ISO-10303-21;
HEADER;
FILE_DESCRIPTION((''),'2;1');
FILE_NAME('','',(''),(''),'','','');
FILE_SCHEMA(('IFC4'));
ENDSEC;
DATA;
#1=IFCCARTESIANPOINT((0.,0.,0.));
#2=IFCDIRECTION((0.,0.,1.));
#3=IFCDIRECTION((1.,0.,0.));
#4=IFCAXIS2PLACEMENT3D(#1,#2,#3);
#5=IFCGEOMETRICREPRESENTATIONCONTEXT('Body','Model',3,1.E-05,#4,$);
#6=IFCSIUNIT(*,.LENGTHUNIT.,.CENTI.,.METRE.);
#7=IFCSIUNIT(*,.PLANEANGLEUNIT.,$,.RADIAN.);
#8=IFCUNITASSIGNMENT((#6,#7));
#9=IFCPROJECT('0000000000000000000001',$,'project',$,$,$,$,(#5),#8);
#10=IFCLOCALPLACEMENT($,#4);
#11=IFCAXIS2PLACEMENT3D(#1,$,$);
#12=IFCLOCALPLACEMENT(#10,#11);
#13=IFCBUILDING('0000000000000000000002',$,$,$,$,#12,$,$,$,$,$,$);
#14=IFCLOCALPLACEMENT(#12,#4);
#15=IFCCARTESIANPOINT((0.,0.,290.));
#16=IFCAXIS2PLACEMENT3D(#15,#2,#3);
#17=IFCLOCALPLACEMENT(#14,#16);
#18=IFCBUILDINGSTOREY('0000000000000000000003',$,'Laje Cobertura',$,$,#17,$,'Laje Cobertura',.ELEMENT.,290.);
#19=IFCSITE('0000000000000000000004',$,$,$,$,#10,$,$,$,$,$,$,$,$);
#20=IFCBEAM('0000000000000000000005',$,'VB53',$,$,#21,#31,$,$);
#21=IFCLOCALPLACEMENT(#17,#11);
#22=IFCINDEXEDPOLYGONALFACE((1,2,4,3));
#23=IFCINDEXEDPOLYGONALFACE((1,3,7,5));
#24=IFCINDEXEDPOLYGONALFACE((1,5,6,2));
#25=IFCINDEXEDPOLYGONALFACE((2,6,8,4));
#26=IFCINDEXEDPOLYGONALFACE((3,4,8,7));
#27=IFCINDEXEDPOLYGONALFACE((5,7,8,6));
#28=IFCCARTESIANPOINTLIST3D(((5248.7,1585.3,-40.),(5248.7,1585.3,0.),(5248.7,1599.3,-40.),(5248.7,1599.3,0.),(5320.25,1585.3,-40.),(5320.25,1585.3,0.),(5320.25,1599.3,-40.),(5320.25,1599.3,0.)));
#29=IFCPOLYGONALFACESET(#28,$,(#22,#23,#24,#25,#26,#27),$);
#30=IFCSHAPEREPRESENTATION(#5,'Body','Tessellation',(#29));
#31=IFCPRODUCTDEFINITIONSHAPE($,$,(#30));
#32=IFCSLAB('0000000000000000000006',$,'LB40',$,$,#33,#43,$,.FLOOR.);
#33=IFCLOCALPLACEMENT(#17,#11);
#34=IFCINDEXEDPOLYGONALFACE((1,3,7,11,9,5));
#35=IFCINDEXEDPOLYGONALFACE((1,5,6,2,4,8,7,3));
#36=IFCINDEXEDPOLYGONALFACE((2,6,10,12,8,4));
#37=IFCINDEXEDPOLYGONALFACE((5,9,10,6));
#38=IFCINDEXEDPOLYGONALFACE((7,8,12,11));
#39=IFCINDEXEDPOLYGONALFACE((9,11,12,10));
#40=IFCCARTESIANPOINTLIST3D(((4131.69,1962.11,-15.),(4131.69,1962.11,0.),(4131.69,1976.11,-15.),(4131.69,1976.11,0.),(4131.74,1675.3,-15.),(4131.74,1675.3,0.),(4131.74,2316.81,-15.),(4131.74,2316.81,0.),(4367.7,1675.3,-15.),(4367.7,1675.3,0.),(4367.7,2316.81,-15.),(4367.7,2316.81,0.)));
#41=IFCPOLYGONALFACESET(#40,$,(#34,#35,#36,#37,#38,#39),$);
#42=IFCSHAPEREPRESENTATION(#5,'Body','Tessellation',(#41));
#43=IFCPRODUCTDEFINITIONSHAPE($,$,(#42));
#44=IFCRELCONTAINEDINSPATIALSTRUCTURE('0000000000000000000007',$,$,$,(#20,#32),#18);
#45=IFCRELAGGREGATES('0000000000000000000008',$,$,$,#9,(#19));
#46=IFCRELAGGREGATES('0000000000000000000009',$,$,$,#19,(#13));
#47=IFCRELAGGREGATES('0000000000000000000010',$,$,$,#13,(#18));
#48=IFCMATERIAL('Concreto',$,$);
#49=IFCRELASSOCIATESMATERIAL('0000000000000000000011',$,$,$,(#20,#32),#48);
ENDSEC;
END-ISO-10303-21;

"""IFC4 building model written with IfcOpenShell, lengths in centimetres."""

from ifc_helpers import new_model, si_unit, frame, origin, origin_with_axes, origin_2d_with_axis, place, context, project, spatial, polyline, rectangle, outline, extrude, material, element, save


model = new_model("IFC4")

# Units and contexts
model_context = context("Model", 3, precision=1e-05, world=origin_with_axes(), identifier="Body")
ifc_project = project(units=[si_unit("LENGTHUNIT", "METRE", prefix="CENTI"), si_unit("PLANEANGLEUNIT", "RADIAN")], contexts=[model_context])

# Site, building, storey
site_placement = place(None, origin_with_axes())
site = spatial("IfcSite", under=ifc_project, at=site_placement)
building_placement = place(site_placement, origin())
building = spatial("IfcBuilding", under=site, at=building_placement)
placement = place(building_placement, origin_with_axes())
storey_placement = place(placement, frame((0.0, 0.0, 290.0), z_axis=(0.0, 0.0, 1.0), x_axis=(1.0, 0.0, 0.0)))
storey = spatial("IfcBuildingStorey", under=building, at=storey_placement, Name="Laje Cobertura", LongName="Laje Cobertura", CompositionType="ELEMENT", Elevation=290.0)

# Shared definitions
ifc_material = material(Name="Concreto")

# Beam
beam_1_placement = place(storey_placement, frame((5284.48, 1592.3, 0.0), z_axis=(0.0, 0.0, 1.0), x_axis=(1.0, 0.0, 0.0)))
element("IfcBeam", 1, at=beam_1_placement, inside=storey, material=ifc_material, Name="VB53", context=model_context, shape_type="SolidModel", body=[
    extrude(rectangle(XDim=14.0, YDim=40.0, at=origin_2d_with_axis()), frame((-35.77, 0.0, -20.0), z_axis=(1.0, 0.0, 0.0), x_axis=(0.0, 1.0, 0.0)), (0.0, 0.0, 1.0), 71.55),
])

# Slab
slab_1_placement = place(storey_placement, frame((4249.69, 1996.06, 0.0), z_axis=(0.0, 0.0, 1.0), x_axis=(1.0, 0.0, 0.0)))
element("IfcSlab", 2, at=slab_1_placement, inside=storey, material=ifc_material, Name="LB40", PredefinedType="FLOOR", context=model_context, shape_type="SolidModel", body=[
    extrude(outline(polyline([(118.0, 320.75), (-117.96, 320.75), (-118.0, -19.95), (-118.0, -33.95), (-117.95, -320.75), (118.0, -320.75), (118.0, 320.75), (118.0, 320.75)])), frame((0.0, 0.0, -15.0), z_axis=(0.0, 0.0, 1.0), x_axis=(1.0, 0.0, 0.0)), (0.0, 0.0, 1.0), 15.0),
])

save(model, "model.ifc")
